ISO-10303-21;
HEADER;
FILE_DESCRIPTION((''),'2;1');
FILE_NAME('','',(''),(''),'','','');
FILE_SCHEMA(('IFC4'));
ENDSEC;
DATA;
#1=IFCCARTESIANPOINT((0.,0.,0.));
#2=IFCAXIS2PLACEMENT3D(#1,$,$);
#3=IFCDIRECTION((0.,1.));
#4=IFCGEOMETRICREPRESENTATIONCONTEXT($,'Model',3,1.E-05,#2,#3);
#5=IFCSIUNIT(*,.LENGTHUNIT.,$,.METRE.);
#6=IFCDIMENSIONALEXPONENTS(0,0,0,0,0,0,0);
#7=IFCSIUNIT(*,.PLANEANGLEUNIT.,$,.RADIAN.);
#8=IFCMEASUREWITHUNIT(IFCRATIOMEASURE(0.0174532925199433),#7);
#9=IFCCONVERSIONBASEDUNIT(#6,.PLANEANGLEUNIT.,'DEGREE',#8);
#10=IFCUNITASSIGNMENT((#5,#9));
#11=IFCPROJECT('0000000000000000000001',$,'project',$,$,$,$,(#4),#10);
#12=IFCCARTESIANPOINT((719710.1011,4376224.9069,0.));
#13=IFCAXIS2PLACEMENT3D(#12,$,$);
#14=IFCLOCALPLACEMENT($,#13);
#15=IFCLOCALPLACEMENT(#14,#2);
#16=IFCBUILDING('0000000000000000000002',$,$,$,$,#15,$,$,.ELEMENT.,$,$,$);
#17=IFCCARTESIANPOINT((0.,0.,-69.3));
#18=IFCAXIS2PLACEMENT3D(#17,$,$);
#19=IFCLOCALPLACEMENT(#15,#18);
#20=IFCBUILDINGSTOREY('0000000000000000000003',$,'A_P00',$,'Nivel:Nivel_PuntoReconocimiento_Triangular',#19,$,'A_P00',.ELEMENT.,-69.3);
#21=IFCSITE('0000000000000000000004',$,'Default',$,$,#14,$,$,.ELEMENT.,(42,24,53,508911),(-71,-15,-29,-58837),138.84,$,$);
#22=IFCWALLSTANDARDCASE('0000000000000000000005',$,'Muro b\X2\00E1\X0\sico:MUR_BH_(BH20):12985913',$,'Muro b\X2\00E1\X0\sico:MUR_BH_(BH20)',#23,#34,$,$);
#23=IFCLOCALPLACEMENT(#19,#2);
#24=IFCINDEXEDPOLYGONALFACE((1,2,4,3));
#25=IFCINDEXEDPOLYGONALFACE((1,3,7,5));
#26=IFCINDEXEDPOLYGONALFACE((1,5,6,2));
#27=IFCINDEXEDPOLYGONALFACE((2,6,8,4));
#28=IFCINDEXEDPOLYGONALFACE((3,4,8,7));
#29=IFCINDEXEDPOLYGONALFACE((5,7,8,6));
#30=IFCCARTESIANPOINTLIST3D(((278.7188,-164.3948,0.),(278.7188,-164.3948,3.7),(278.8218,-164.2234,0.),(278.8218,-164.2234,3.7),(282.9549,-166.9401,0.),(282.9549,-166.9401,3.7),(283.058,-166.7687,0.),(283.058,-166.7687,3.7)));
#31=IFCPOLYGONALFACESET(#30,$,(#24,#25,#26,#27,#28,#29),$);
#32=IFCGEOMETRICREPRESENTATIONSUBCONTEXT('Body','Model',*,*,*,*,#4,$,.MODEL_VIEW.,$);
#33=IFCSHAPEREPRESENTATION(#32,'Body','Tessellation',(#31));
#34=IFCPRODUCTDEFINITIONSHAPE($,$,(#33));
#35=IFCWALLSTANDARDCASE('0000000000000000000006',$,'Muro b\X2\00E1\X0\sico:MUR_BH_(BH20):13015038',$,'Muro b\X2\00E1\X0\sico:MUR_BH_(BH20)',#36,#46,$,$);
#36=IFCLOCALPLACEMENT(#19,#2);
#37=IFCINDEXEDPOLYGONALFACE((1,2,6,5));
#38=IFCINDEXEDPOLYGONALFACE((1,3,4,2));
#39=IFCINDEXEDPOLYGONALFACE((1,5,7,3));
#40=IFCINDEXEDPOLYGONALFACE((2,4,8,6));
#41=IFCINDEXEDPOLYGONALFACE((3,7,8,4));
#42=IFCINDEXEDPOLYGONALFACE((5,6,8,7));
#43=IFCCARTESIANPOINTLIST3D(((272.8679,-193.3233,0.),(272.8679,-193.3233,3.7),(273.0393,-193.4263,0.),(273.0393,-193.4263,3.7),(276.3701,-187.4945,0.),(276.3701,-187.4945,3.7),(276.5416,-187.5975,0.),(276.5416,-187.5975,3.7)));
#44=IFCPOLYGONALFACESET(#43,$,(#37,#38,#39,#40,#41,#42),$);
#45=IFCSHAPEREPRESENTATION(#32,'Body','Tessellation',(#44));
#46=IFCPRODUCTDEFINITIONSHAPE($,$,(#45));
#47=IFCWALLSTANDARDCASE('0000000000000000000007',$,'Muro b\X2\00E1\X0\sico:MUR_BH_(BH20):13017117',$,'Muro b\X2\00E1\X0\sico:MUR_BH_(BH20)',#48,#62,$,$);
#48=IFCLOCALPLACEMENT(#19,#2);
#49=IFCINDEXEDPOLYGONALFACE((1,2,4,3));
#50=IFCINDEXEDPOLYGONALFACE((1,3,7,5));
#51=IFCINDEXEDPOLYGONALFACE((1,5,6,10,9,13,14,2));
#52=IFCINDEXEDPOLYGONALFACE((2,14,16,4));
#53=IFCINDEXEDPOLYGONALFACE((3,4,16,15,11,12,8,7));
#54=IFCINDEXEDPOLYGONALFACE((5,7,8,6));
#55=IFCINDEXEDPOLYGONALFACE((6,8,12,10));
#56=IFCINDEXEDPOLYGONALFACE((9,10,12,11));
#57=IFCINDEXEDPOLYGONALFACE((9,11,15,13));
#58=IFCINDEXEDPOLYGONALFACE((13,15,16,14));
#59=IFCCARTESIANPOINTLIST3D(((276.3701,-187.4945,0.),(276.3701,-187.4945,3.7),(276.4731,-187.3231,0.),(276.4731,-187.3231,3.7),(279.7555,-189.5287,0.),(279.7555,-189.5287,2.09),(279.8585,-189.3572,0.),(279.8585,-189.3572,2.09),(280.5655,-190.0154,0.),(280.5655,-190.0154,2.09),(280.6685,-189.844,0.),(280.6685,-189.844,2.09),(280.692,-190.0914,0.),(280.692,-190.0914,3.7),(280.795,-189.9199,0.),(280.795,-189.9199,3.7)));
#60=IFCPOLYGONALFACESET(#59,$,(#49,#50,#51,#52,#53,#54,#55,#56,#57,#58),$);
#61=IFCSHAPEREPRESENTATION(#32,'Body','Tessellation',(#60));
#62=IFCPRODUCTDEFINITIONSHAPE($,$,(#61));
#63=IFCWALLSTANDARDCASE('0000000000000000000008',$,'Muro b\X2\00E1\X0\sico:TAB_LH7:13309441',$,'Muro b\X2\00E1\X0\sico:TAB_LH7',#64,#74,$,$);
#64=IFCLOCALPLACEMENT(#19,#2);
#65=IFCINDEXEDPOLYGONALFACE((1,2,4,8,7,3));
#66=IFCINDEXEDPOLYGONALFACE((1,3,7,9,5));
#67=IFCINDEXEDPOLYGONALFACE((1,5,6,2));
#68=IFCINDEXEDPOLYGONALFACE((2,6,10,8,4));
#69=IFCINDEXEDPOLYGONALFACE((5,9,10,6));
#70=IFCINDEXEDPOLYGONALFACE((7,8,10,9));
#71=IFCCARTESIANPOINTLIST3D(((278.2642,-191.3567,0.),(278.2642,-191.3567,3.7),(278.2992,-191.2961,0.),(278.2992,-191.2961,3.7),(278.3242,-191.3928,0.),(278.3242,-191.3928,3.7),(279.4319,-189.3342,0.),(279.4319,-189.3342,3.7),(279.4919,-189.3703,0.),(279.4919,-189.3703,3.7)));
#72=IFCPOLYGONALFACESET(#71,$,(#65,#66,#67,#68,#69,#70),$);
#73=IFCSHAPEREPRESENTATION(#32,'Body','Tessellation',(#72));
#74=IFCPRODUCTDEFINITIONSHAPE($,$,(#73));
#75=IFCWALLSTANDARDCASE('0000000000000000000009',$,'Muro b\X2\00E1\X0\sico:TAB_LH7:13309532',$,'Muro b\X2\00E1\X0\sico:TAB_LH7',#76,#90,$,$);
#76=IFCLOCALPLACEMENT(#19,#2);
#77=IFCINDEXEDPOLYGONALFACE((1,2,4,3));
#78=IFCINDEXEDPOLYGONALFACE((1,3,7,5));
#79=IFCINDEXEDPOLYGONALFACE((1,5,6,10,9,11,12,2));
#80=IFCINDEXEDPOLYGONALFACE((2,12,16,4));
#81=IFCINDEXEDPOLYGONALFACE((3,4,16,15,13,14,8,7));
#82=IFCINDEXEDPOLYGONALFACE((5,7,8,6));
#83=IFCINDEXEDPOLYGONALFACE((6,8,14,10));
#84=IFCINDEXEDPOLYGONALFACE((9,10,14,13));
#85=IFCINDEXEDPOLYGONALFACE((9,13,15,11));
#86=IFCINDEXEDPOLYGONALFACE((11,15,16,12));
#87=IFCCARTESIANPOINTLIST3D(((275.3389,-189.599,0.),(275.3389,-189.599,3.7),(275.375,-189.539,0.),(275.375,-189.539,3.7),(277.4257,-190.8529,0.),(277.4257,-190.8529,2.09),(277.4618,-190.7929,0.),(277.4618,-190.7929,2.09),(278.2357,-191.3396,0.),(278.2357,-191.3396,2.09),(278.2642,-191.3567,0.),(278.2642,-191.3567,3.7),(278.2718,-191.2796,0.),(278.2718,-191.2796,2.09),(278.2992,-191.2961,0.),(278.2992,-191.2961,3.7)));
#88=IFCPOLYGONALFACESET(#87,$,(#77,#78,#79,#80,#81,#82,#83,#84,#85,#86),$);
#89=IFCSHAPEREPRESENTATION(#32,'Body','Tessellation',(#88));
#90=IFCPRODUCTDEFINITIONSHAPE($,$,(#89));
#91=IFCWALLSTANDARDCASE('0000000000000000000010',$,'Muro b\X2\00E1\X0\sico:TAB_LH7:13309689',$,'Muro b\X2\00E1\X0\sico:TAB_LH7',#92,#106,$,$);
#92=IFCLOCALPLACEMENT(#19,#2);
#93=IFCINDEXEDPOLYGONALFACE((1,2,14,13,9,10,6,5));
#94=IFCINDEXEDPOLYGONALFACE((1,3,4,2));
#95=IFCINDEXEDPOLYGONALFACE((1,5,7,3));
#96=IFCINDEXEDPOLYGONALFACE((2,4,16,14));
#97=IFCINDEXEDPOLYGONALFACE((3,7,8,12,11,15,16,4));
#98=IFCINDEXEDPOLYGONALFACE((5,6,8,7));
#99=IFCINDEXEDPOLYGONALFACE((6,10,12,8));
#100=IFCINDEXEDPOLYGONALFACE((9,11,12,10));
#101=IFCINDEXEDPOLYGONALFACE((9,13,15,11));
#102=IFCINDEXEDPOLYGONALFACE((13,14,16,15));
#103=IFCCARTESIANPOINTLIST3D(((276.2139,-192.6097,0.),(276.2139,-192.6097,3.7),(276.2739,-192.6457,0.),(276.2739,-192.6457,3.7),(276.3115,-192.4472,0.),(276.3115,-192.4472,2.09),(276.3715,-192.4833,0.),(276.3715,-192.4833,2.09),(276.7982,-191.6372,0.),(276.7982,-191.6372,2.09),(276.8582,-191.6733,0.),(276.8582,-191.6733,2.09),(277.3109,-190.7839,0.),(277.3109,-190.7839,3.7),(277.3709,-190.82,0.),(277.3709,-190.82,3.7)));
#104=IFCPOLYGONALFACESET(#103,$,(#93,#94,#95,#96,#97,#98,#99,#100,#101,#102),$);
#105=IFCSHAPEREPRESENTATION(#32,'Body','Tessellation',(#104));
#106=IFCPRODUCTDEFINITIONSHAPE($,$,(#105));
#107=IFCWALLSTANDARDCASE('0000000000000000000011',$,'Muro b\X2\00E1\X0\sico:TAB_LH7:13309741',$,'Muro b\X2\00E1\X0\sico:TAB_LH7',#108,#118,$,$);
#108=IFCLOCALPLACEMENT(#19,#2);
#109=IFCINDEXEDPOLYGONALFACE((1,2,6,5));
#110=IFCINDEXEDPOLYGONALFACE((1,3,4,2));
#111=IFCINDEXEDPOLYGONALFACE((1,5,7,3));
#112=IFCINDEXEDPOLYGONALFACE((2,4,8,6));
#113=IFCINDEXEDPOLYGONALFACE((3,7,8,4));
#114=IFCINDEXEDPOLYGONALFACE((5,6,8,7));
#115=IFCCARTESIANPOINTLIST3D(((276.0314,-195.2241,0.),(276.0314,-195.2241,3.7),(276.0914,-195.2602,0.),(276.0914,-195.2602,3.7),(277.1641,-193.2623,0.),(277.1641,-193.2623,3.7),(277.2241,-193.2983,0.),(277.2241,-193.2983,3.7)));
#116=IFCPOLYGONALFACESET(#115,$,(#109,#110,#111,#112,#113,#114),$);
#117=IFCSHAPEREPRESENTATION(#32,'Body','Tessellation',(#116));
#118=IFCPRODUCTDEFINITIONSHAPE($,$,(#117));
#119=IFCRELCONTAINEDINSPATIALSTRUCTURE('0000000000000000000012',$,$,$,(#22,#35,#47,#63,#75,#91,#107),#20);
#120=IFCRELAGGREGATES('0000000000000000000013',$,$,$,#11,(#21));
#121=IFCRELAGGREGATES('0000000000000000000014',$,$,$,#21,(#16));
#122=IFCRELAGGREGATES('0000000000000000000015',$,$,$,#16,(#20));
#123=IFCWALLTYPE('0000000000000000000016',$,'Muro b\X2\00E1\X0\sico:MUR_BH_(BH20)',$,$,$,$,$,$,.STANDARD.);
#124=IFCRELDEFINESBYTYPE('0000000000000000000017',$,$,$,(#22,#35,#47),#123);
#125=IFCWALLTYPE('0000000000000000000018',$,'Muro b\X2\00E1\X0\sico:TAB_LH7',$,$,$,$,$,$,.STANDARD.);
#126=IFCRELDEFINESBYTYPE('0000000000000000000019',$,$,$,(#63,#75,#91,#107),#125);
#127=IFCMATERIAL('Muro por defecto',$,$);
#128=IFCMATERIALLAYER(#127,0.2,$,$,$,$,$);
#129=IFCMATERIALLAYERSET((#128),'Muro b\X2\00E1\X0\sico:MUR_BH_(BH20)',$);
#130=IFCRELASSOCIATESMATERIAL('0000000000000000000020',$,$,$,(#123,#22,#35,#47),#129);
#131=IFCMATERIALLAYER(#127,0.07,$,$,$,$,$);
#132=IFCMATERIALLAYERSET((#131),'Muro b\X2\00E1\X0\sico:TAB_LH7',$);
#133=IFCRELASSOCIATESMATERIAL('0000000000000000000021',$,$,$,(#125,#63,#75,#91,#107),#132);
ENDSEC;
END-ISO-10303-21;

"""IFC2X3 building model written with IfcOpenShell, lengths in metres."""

from ifc_helpers import new_model, entity, si_unit, converted_unit, direction, frame, frame_2d, origin, origin_2d_with_axis, place, context, subcontext, project, spatial, polyline, rectangle, outline, extrude, material, layer, layer_set, layer_usage, type_object, element, save


model = new_model("IFC2X3")

# Units and contexts
model_context = context("Model", 3, precision=1e-05, world=origin(), true_north=direction((0.0, 1.0)))
body_context = subcontext(model_context, "Body", "Model", "MODEL_VIEW")
ifc_project = project(units=[si_unit("LENGTHUNIT", "METRE"), converted_unit("PLANEANGLEUNIT", "DEGREE", entity("IfcRatioMeasure", 0.0174532925199433), si_unit("PLANEANGLEUNIT", "RADIAN"), dimensions=[0, 0, 0, 0, 0, 0, 0])], contexts=[model_context])

# Site, building, storey
site_placement = place(None, frame((719710.1011, 4376224.9069, 0.0)))
site = spatial("IfcSite", under=ifc_project, at=site_placement, Name="Default", CompositionType="ELEMENT", RefLatitude=(42, 24, 53, 508911), RefLongitude=(-71, -15, -29, -58837), RefElevation=138.84)
building_placement = place(site_placement, origin())
building = spatial("IfcBuilding", under=site, at=building_placement, CompositionType="ELEMENT")
storey_placement = place(building_placement, frame((0.0, 0.0, -69.3)))
storey = spatial("IfcBuildingStorey", under=building, at=storey_placement, Name="A_P00", ObjectType="Nivel:Nivel_PuntoReconocimiento_Triangular", LongName="A_P00", CompositionType="ELEMENT", Elevation=-69.3)

# Walls
ifc_material_1 = material(Name="Muro por defecto")
ifc_layer_1 = layer(ifc_material_1, 0.2)
ifc_layer_set_1 = layer_set([ifc_layer_1], Name="Muro básico:MUR_BH_(BH20)")
wall_type_1 = type_object("IfcWallType", Name="Muro básico:MUR_BH_(BH20)", PredefinedType="STANDARD", material=ifc_layer_set_1)
ifc_layer_usage_1 = layer_usage(ifc_layer_set_1, "AXIS2", "NEGATIVE", 0.1)
wall_1_placement = place(storey_placement, frame((283.0064, -166.8544, 0.0), z_axis=(0.0, 0.0, 1.0), x_axis=(-0.857167, 0.515038, 0.0)))
element("IfcWallStandardCase", 1, at=wall_1_placement, inside=storey, type_object=wall_type_1, material=ifc_layer_usage_1, Name="Muro básico:MUR_BH_(BH20):12985913", ObjectType="Muro básico:MUR_BH_(BH20)", context=body_context, shape_type="SweptSolid", body=[
    extrude(rectangle(XDim=4.942, YDim=0.2, at=frame_2d((2.471, 0.0), x_axis=(-1.0, 0.0))), origin(), (0.0, 0.0, 1.0), 3.7),
])
ifc_layer_usage_2 = layer_usage(ifc_layer_set_1, "AXIS2", "NEGATIVE", 0.1)
wall_2_placement = place(storey_placement, frame((276.4558, -187.546, 0.0), z_axis=(0.0, 0.0, 1.0), x_axis=(-0.515038, -0.857167, 0.0)))
element("IfcWallStandardCase", 2, at=wall_2_placement, inside=storey, type_object=wall_type_1, material=ifc_layer_usage_2, Name="Muro básico:MUR_BH_(BH20):13015038", ObjectType="Muro básico:MUR_BH_(BH20)", context=body_context, shape_type="SweptSolid", body=[
    extrude(rectangle(XDim=6.8, YDim=0.2, at=frame_2d((3.4, 0.0), x_axis=(-1.0, 0.0))), origin(), (0.0, 0.0, 1.0), 3.7),
])

# Wall, opening
ifc_layer_usage_3 = layer_usage(ifc_layer_set_1, "AXIS2", "NEGATIVE", 0.1)
wall_3_placement = place(storey_placement, frame((276.4216, -187.4088, 0.0), z_axis=(0.0, 0.0, 1.0), x_axis=(0.857167, -0.515038, 0.0)))
wall_3 = element("IfcWallStandardCase", 3, at=wall_3_placement, inside=storey, type_object=wall_type_1, material=ifc_layer_usage_3, Name="Muro básico:MUR_BH_(BH20):13017117", ObjectType="Muro básico:MUR_BH_(BH20)", context=body_context, shape_type="SweptSolid", body=[
    extrude(rectangle(XDim=5.042, YDim=0.2, at=frame_2d((2.521, 0.0), x_axis=(-1.0, 0.0))), origin(), (0.0, 0.0, 1.0), 3.7),
])
opening_1_placement = place(wall_3_placement, frame((-333.4622, 18.273, 0.0), z_axis=(0.0, 0.0, 1.0), x_axis=(0.857167, 0.515038, 0.0)))
element("IfcOpeningElement", 4, at=opening_1_placement, cuts=wall_3, ObjectType="Opening", context=body_context, shape_type="SweptSolid", body=[
    extrude(rectangle(XDim=2.09, YDim=0.945, at=frame_2d((0.0, 0.0), x_axis=(1.0, 0.0))), frame((280.1605, -189.772, 1.045), z_axis=(0.515038, 0.857167, 0.0), x_axis=(0.0, 0.0, -1.0)), (0.0, 0.0, 1.0), 0.2),
])

# Wall
ifc_layer_2 = layer(ifc_material_1, 0.07)
ifc_layer_set_2 = layer_set([ifc_layer_2], Name="Muro básico:TAB_LH7")
ifc_layer_usage_4 = layer_usage(ifc_layer_set_2, "AXIS2", "NEGATIVE", 0.035)
wall_type_2 = type_object("IfcWallType", Name="Muro básico:TAB_LH7", PredefinedType="STANDARD", material=ifc_layer_set_2)
wall_4_placement = place(storey_placement, frame((279.4622, -189.3517, 0.0), z_axis=(0.0, 0.0, 1.0), x_axis=(-0.5, -0.866025, 0.0)))
element("IfcWallStandardCase", 5, at=wall_4_placement, inside=storey, type_object=wall_type_2, material=ifc_layer_usage_4, Name="Muro básico:TAB_LH7:13309441", ObjectType="Muro básico:TAB_LH7", context=body_context, shape_type="SweptSolid", body=[
    extrude(outline(polyline([(2.3354, -0.035), (2.3366, 0.035), (0.0012, 0.035), (0.0, -0.035), (2.2653, -0.035), (2.3354, -0.035)])), origin(), (0.0, 0.0, 1.0), 3.7),
])

# Walls, openings
ifc_layer_usage_5 = layer_usage(ifc_layer_set_2, "AXIS2", "NEGATIVE", 0.035)
wall_5_placement = place(storey_placement, frame((278.2823, -191.3267, 0.0), z_axis=(0.0, 0.0, 1.0), x_axis=(-0.857167, 0.515038, 0.0)))
wall_5 = element("IfcWallStandardCase", 6, at=wall_5_placement, inside=storey, type_object=wall_type_2, material=ifc_layer_usage_5, Name="Muro básico:TAB_LH7:13309532", ObjectType="Muro básico:TAB_LH7", context=body_context, shape_type="SweptSolid", body=[
    extrude(outline(polyline([(0.0012, -0.035), (3.4127, -0.035), (3.4127, 0.035), (1.1122, 0.035), (1.0422, 0.035), (0.0, 0.035), (0.0012, -0.035)])), origin(), (0.0, 0.0, 1.0), 3.7),
])
opening_2_placement = place(wall_5_placement, frame((337.075, -20.673, 0.0), z_axis=(0.0, 0.0, 1.0), x_axis=(-0.857167, -0.515038, 0.0)))
element("IfcOpeningElement", 7, at=opening_2_placement, cuts=wall_5, ObjectType="Opening", context=body_context, shape_type="SweptSolid", body=[
    extrude(rectangle(XDim=2.09, YDim=0.945, at=frame_2d((0.0, 0.0), x_axis=(0.0, 1.0))), frame((277.8668, -191.0362, 1.045), z_axis=(-0.515038, -0.857167, 0.0), x_axis=(-0.857167, 0.515038, 0.0)), (0.0, 0.0, 1.0), 0.07),
])
ifc_layer_usage_6 = layer_usage(ifc_layer_set_2, "AXIS2", "NEGATIVE", 0.035)
wall_6_placement = place(storey_placement, frame((277.3409, -190.8019, 0.0), z_axis=(0.0, 0.0, 1.0), x_axis=(-0.515038, -0.857167, 0.0)))
wall_6 = element("IfcWallStandardCase", 8, at=wall_6_placement, inside=storey, type_object=wall_type_2, material=ifc_layer_usage_6, Name="Muro básico:TAB_LH7:13309689", ObjectType="Muro básico:TAB_LH7", context=body_context, shape_type="SweptSolid", body=[
    extrude(rectangle(XDim=2.13, YDim=0.07, at=frame_2d((1.065, 0.0), x_axis=(-1.0, 0.0))), origin(), (0.0, 0.0, 1.0), 3.7),
])
opening_3_placement = place(wall_6_placement, frame((-20.708, -335.9978, 0.0), z_axis=(0.0, 0.0, 1.0), x_axis=(-0.515038, 0.857167, 0.0)))
element("IfcOpeningElement", 9, at=opening_3_placement, cuts=wall_6, ObjectType="Opening", context=body_context, shape_type="SweptSolid", body=[
    extrude(rectangle(XDim=2.09, YDim=0.945, at=origin_2d_with_axis()), frame((276.5548, -192.0422, 1.045), z_axis=(0.857167, -0.515038, 0.0), x_axis=(0.0, 0.0, -1.0)), (0.0, 0.0, 1.0), 0.07),
])

# Wall
ifc_layer_usage_7 = layer_usage(ifc_layer_set_2, "AXIS2", "NEGATIVE", 0.035)
wall_7_placement = place(storey_placement, frame((277.1944, -193.2798, 0.0), z_axis=(0.0, 0.0, 1.0), x_axis=(-0.5, -0.866025, 0.0)))
element("IfcWallStandardCase", 10, at=wall_7_placement, inside=storey, type_object=wall_type_2, material=ifc_layer_usage_7, Name="Muro básico:TAB_LH7:13309741", ObjectType="Muro básico:TAB_LH7", context=body_context, shape_type="SweptSolid", body=[
    extrude(outline(polyline([(2.2653, -0.035), (2.2666, 0.035), (0.0012, 0.035), (0.0, -0.035), (2.2653, -0.035)])), origin(), (0.0, 0.0, 1.0), 3.7),
])

save(model, "model.ifc")
